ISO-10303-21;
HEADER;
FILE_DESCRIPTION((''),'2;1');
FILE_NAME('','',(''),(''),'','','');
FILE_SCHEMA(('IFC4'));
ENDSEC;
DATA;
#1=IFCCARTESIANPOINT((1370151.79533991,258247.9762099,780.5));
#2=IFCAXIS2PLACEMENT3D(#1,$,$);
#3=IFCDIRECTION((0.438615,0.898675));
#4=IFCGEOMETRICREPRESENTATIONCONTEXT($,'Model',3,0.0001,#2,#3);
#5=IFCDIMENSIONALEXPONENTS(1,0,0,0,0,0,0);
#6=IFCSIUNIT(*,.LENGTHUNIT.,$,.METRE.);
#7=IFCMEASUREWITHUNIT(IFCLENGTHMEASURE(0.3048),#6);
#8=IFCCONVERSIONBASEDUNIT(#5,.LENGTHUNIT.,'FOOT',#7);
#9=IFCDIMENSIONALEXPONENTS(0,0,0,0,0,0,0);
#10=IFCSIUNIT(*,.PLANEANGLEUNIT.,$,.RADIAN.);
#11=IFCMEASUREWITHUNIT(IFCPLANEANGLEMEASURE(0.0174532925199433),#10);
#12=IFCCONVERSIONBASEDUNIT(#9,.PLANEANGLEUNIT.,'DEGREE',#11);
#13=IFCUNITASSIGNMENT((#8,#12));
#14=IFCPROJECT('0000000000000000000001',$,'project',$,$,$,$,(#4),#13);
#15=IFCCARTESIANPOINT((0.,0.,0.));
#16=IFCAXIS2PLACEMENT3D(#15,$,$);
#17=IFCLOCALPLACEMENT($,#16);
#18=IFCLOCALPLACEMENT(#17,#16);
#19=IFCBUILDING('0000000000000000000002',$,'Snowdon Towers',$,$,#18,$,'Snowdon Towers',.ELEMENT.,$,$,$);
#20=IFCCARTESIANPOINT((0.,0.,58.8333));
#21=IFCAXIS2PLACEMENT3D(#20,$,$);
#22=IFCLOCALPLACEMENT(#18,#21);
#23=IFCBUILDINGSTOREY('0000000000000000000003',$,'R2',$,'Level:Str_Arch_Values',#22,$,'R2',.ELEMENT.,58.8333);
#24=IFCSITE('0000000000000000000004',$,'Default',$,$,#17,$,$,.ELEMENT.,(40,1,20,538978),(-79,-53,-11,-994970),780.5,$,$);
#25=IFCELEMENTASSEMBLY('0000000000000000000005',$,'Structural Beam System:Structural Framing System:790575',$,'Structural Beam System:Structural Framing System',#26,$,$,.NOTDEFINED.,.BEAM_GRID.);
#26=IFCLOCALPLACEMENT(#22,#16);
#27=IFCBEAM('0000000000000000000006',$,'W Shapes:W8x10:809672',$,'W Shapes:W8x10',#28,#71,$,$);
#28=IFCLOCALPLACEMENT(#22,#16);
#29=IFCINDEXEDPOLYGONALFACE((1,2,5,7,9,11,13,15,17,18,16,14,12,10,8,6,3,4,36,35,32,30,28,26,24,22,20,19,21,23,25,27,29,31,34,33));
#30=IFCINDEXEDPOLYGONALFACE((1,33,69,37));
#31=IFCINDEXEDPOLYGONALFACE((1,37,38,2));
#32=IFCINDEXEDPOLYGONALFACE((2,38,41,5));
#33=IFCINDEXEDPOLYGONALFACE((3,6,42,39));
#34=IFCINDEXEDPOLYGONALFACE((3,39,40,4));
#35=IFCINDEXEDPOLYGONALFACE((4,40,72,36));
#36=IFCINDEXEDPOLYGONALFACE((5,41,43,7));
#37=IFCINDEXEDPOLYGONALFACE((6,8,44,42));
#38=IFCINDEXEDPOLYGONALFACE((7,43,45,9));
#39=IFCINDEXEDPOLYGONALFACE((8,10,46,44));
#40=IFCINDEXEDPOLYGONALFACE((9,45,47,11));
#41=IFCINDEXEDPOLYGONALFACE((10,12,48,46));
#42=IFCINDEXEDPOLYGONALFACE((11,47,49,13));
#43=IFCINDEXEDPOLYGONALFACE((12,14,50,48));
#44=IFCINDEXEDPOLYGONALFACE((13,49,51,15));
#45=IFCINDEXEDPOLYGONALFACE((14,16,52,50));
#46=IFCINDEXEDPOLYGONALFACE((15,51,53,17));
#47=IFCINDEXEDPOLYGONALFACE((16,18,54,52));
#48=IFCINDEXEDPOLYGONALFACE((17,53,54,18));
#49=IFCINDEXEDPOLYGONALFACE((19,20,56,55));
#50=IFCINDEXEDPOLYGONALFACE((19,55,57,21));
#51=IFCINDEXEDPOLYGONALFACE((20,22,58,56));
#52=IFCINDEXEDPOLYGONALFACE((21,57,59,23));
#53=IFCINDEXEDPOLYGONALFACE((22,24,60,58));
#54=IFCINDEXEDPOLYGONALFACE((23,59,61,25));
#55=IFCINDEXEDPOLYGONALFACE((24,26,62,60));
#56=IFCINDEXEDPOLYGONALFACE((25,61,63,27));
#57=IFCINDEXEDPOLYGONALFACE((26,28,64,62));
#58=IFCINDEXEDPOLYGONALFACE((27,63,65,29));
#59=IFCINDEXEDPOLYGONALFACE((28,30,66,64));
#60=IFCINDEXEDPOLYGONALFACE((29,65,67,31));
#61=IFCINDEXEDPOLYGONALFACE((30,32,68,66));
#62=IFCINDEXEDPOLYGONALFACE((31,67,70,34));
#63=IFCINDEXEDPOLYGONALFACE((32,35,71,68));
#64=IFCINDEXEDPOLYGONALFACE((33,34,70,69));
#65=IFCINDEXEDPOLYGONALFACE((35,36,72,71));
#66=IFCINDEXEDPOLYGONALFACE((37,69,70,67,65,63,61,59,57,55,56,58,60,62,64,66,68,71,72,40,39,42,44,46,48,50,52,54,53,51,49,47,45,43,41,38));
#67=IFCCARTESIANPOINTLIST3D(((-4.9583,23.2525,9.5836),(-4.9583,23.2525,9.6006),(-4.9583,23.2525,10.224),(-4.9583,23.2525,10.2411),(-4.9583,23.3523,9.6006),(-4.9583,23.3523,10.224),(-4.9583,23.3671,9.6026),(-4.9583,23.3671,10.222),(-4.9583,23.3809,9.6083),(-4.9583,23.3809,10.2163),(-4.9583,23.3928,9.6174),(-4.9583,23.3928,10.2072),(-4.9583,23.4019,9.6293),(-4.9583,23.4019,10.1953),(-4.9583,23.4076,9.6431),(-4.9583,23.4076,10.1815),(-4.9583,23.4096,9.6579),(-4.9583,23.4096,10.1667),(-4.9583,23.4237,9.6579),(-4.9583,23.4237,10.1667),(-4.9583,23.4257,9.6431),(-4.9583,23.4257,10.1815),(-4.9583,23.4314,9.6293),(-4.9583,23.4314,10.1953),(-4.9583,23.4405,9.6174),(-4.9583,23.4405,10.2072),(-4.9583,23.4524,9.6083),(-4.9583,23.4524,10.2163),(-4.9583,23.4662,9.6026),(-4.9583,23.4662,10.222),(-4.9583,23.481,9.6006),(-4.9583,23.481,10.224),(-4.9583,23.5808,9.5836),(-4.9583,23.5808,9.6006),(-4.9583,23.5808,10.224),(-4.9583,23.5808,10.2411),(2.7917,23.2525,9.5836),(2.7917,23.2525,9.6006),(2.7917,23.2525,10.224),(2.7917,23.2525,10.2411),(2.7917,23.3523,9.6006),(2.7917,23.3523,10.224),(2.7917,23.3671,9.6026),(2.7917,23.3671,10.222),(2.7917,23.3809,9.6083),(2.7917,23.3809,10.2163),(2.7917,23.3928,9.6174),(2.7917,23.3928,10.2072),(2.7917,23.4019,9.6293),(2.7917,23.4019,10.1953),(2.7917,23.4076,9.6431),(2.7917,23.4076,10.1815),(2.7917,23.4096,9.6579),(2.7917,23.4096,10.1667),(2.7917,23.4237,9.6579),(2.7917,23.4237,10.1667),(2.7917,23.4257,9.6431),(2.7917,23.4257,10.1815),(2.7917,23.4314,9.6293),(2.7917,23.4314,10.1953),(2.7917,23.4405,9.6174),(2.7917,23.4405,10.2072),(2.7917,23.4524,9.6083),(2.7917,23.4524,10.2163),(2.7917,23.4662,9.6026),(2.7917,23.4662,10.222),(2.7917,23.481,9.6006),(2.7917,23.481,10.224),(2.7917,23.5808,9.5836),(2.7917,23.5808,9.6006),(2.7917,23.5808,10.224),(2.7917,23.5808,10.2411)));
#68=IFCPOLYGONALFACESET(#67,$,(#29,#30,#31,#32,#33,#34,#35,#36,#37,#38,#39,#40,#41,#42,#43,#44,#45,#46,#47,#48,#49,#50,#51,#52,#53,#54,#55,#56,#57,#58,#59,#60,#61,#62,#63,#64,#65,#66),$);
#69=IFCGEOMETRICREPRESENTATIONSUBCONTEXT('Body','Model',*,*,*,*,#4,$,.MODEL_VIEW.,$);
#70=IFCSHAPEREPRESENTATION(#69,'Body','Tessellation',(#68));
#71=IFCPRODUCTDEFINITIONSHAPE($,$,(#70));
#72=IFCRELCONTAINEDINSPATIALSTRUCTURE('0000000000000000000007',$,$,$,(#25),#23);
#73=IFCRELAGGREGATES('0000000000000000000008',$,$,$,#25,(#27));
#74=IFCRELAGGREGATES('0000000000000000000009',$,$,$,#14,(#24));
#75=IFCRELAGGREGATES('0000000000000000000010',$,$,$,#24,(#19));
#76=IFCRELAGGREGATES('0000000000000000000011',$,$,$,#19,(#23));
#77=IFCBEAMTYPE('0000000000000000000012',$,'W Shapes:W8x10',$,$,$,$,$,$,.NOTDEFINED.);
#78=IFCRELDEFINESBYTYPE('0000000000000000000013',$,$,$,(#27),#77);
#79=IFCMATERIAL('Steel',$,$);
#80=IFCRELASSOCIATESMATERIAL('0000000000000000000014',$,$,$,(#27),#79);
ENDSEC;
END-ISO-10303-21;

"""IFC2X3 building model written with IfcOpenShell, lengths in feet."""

from ifc_helpers import new_model, entity, si_unit, converted_unit, direction, frame, frame_2d, origin, place, context, subcontext, project, spatial, i_section, extrude, material, type_object, element, aggregate, save


model = new_model("IFC2X3")

# Units and contexts
model_context = context("Model", 3, precision=0.0001, world=frame((1370151.79533991, 258247.9762099, 780.5)), true_north=direction((0.438615, 0.898675)))
body_context = subcontext(model_context, "Body", "Model", "MODEL_VIEW")
ifc_project = project(units=[converted_unit("LENGTHUNIT", "FOOT", entity("IfcLengthMeasure", 0.3048), si_unit("LENGTHUNIT", "METRE"), dimensions=[1, 0, 0, 0, 0, 0, 0]), converted_unit("PLANEANGLEUNIT", "DEGREE", entity("IfcPlaneAngleMeasure", 0.0174532925199433), si_unit("PLANEANGLEUNIT", "RADIAN"), dimensions=[0, 0, 0, 0, 0, 0, 0])], contexts=[model_context])

# Site, building, storey
site_placement = place(None, origin())
site = spatial("IfcSite", under=ifc_project, at=site_placement, Name="Default", CompositionType="ELEMENT", RefLatitude=(40, 1, 20, 538978), RefLongitude=(-79, -53, -11, -994970), RefElevation=780.5)
building_placement = place(site_placement, origin())
building = spatial("IfcBuilding", under=site, at=building_placement, Name="Snowdon Towers", LongName="Snowdon Towers", CompositionType="ELEMENT")
storey_placement = place(building_placement, frame((0.0, 0.0, 58.8333)))
storey = spatial("IfcBuildingStorey", under=building, at=storey_placement, Name="R2", ObjectType="Level:Str_Arch_Values", LongName="R2", CompositionType="ELEMENT", Elevation=58.8333)

# Shared definitions
ifc_material_1 = material(Name="Steel")
beam_type = type_object("IfcBeamType", Name="W Shapes:W8x10", PredefinedType="NOTDEFINED")

# Element assembly, beam
assembly_1_placement = place(storey_placement, origin())
assembly_1 = element("IfcElementAssembly", 1, at=assembly_1_placement, inside=storey, Name="Structural Beam System:Structural Framing System:790575", ObjectType="Structural Beam System:Structural Framing System", AssemblyPlace="NOTDEFINED", PredefinedType="BEAM_GRID")
beam_1_placement = place(assembly_1_placement, frame((3.0833, 23.4167, 10.2411), z_axis=(0.0, 0.0, 1.0), x_axis=(-1.0, 0.0, 0.0)))
beam_1 = element("IfcBeam", 2, at=beam_1_placement, type_object=beam_type, material=ifc_material_1, Name="W Shapes:W8x10:809672", ObjectType="W Shapes:W8x10", context=body_context, shape_type="SweptSolid", body=[
    extrude(i_section(OverallWidth=0.3283, OverallDepth=0.6575, WebThickness=0.0142, FlangeThickness=0.0171, FilletRadius=0.0573, at=frame_2d((0.0, 0.0), x_axis=(0.0, 1.0))), frame((0.2917, 0.0, -0.3288), z_axis=(1.0, 0.0, 0.0), x_axis=(0.0, 0.0, -1.0)), (0.0, 0.0, 1.0), 7.75),
])
aggregate(assembly_1, [beam_1])

save(model, "model.ifc")
